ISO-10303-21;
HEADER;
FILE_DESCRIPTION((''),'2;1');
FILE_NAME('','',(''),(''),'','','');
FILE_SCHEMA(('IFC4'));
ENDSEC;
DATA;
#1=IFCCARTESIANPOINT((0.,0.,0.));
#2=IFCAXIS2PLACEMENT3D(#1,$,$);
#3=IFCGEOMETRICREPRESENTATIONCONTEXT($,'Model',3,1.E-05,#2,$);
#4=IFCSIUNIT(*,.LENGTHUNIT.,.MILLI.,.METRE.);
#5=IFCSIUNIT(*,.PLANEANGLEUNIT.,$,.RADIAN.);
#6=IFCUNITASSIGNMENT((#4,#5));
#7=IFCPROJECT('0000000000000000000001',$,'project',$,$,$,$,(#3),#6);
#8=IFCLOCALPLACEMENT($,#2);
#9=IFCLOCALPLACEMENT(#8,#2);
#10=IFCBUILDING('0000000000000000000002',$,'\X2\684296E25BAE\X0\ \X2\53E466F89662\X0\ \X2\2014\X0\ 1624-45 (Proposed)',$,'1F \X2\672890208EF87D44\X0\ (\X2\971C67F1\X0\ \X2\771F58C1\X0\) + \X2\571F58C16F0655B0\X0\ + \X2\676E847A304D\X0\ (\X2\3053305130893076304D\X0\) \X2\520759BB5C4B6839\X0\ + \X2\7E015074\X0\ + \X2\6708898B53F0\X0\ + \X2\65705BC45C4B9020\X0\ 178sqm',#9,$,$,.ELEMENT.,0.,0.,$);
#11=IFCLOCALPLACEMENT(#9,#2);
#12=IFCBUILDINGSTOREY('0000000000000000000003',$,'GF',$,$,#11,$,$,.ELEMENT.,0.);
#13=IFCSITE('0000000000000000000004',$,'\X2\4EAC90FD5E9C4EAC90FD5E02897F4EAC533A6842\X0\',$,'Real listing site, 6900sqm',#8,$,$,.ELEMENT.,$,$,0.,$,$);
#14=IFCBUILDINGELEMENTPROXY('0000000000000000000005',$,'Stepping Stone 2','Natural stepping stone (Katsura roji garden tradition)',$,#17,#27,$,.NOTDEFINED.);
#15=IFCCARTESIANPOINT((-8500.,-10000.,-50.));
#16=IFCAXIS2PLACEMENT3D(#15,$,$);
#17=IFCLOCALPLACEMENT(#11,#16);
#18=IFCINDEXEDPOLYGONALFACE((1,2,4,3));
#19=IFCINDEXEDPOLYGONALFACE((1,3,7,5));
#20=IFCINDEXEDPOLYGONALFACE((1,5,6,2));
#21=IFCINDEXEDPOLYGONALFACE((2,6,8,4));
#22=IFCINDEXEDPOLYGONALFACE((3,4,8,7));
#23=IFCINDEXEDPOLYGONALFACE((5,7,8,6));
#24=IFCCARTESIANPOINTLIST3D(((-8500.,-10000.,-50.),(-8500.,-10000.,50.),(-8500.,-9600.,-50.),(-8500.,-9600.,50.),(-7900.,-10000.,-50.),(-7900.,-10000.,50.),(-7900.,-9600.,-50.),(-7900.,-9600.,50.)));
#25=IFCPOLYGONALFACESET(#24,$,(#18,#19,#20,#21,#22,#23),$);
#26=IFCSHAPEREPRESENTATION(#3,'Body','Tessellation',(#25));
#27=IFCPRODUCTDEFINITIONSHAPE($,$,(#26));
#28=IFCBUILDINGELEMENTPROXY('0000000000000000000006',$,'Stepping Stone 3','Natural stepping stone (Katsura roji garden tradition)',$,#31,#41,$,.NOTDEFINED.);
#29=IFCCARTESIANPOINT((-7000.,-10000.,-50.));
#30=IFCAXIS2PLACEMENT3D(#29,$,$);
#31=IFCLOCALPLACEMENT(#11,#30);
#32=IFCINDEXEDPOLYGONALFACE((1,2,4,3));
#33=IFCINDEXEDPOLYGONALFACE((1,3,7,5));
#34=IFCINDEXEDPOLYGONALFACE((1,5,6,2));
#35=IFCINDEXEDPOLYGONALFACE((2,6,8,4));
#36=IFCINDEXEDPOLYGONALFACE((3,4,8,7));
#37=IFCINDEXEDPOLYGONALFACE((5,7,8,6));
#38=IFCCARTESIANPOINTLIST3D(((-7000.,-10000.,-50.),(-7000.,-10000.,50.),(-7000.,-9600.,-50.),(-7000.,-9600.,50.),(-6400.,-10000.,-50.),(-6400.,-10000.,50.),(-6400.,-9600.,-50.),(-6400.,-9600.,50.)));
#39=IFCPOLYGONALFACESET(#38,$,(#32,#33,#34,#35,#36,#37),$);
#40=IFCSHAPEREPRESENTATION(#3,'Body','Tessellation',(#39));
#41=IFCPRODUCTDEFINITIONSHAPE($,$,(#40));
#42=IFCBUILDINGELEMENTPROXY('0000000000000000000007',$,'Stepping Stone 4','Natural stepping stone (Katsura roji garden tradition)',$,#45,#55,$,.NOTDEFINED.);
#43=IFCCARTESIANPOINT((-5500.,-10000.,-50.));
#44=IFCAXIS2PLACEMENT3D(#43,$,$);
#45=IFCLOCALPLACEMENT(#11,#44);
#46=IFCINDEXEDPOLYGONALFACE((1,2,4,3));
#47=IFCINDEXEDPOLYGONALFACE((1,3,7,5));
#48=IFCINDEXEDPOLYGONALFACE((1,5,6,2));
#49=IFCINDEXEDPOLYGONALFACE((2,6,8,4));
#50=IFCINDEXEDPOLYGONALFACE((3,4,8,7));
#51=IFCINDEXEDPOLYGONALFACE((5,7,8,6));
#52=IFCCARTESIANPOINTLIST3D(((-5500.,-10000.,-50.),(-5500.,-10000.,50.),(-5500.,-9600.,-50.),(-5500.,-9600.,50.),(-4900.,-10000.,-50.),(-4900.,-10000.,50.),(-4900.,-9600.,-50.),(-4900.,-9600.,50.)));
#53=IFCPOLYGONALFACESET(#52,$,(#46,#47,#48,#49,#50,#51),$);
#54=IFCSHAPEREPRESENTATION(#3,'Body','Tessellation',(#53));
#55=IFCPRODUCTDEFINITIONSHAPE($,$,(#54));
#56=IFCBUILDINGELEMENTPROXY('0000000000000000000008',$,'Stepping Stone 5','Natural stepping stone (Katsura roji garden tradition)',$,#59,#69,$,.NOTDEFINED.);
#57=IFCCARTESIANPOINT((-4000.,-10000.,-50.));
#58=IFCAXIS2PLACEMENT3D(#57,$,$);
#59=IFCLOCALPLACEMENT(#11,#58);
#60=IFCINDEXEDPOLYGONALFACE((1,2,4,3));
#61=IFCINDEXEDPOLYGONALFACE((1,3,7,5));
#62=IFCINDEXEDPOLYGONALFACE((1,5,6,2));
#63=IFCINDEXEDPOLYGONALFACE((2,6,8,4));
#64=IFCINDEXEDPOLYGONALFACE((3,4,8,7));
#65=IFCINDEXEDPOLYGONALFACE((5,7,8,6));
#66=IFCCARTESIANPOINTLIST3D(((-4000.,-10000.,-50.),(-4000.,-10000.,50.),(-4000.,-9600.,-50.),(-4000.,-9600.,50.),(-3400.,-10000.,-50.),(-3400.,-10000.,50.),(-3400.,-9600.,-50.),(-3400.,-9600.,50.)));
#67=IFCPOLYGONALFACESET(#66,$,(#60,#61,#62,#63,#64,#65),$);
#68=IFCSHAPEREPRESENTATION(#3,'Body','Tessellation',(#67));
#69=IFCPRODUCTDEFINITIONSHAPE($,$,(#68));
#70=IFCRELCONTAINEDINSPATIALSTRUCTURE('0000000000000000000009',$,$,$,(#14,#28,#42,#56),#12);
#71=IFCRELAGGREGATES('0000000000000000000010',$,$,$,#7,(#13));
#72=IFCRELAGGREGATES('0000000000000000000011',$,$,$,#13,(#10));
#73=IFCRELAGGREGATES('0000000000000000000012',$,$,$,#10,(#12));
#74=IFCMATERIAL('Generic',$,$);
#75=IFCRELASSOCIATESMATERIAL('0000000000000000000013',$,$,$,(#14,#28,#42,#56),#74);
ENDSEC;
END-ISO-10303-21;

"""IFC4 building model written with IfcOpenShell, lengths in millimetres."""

from ifc_helpers import new_model, si_unit, frame, frame_2d, origin, place, context, project, spatial, rectangle, extrude, material, element, save


model = new_model("IFC4")

# Units and contexts
model_context = context("Model", 3, precision=1e-05, world=origin())
ifc_project = project(units=[si_unit("LENGTHUNIT", "METRE", prefix="MILLI"), si_unit("PLANEANGLEUNIT", "RADIAN")], contexts=[model_context])

# Site, building, storey
site_placement = place(None, origin())
site = spatial("IfcSite", under=ifc_project, at=site_placement, Name="京都府京都市西京区桂", ObjectType="Real listing site, 6900sqm", CompositionType="ELEMENT", RefElevation=0.0)
building_placement = place(site_placement, origin())
building = spatial("IfcBuilding", under=site, at=building_placement, Name="桂離宮 古書院 — 1624-45 (Proposed)", ObjectType="1F 木造軸組 (霜柱 真壁) + 土壁漆喰 + 杮葺き (こけらぶき) 切妻屋根 + 縁側 + 月見台 + 数寄屋造 178sqm", CompositionType="ELEMENT", ElevationOfRefHeight=0.0, ElevationOfTerrain=0.0)
storey_placement = place(building_placement, origin())
storey = spatial("IfcBuildingStorey", under=building, at=storey_placement, Name="GF", CompositionType="ELEMENT", Elevation=0.0)

# Shared definitions
ifc_material_1 = material(Name="Generic")

# Building element proxies
proxy_1_placement = place(storey_placement, frame((-8500.0, -10000.0, -50.0)))
element("IfcBuildingElementProxy", 1, at=proxy_1_placement, inside=storey, material=ifc_material_1, Name="Stepping Stone 2", Description="Natural stepping stone (Katsura roji garden tradition)", PredefinedType="NOTDEFINED", context=model_context, shape_type="SweptSolid", body=[
    extrude(rectangle(XDim=600.0, YDim=400.0, at=frame_2d((300.0, 200.0))), frame((-8500.0, -10000.0, -50.0)), (0.0, 0.0, 1.0), 100.0),
])
proxy_2_placement = place(storey_placement, frame((-7000.0, -10000.0, -50.0)))
element("IfcBuildingElementProxy", 2, at=proxy_2_placement, inside=storey, material=ifc_material_1, Name="Stepping Stone 3", Description="Natural stepping stone (Katsura roji garden tradition)", PredefinedType="NOTDEFINED", context=model_context, shape_type="SweptSolid", body=[
    extrude(rectangle(XDim=600.0, YDim=400.0, at=frame_2d((300.0, 200.0))), frame((-7000.0, -10000.0, -50.0)), (0.0, 0.0, 1.0), 100.0),
])
proxy_3_placement = place(storey_placement, frame((-5500.0, -10000.0, -50.0)))
element("IfcBuildingElementProxy", 3, at=proxy_3_placement, inside=storey, material=ifc_material_1, Name="Stepping Stone 4", Description="Natural stepping stone (Katsura roji garden tradition)", PredefinedType="NOTDEFINED", context=model_context, shape_type="SweptSolid", body=[
    extrude(rectangle(XDim=600.0, YDim=400.0, at=frame_2d((300.0, 200.0))), frame((-5500.0, -10000.0, -50.0)), (0.0, 0.0, 1.0), 100.0),
])
proxy_4_placement = place(storey_placement, frame((-4000.0, -10000.0, -50.0)))
element("IfcBuildingElementProxy", 4, at=proxy_4_placement, inside=storey, material=ifc_material_1, Name="Stepping Stone 5", Description="Natural stepping stone (Katsura roji garden tradition)", PredefinedType="NOTDEFINED", context=model_context, shape_type="SweptSolid", body=[
    extrude(rectangle(XDim=600.0, YDim=400.0, at=frame_2d((300.0, 200.0))), frame((-4000.0, -10000.0, -50.0)), (0.0, 0.0, 1.0), 100.0),
])

save(model, "model.ifc")
